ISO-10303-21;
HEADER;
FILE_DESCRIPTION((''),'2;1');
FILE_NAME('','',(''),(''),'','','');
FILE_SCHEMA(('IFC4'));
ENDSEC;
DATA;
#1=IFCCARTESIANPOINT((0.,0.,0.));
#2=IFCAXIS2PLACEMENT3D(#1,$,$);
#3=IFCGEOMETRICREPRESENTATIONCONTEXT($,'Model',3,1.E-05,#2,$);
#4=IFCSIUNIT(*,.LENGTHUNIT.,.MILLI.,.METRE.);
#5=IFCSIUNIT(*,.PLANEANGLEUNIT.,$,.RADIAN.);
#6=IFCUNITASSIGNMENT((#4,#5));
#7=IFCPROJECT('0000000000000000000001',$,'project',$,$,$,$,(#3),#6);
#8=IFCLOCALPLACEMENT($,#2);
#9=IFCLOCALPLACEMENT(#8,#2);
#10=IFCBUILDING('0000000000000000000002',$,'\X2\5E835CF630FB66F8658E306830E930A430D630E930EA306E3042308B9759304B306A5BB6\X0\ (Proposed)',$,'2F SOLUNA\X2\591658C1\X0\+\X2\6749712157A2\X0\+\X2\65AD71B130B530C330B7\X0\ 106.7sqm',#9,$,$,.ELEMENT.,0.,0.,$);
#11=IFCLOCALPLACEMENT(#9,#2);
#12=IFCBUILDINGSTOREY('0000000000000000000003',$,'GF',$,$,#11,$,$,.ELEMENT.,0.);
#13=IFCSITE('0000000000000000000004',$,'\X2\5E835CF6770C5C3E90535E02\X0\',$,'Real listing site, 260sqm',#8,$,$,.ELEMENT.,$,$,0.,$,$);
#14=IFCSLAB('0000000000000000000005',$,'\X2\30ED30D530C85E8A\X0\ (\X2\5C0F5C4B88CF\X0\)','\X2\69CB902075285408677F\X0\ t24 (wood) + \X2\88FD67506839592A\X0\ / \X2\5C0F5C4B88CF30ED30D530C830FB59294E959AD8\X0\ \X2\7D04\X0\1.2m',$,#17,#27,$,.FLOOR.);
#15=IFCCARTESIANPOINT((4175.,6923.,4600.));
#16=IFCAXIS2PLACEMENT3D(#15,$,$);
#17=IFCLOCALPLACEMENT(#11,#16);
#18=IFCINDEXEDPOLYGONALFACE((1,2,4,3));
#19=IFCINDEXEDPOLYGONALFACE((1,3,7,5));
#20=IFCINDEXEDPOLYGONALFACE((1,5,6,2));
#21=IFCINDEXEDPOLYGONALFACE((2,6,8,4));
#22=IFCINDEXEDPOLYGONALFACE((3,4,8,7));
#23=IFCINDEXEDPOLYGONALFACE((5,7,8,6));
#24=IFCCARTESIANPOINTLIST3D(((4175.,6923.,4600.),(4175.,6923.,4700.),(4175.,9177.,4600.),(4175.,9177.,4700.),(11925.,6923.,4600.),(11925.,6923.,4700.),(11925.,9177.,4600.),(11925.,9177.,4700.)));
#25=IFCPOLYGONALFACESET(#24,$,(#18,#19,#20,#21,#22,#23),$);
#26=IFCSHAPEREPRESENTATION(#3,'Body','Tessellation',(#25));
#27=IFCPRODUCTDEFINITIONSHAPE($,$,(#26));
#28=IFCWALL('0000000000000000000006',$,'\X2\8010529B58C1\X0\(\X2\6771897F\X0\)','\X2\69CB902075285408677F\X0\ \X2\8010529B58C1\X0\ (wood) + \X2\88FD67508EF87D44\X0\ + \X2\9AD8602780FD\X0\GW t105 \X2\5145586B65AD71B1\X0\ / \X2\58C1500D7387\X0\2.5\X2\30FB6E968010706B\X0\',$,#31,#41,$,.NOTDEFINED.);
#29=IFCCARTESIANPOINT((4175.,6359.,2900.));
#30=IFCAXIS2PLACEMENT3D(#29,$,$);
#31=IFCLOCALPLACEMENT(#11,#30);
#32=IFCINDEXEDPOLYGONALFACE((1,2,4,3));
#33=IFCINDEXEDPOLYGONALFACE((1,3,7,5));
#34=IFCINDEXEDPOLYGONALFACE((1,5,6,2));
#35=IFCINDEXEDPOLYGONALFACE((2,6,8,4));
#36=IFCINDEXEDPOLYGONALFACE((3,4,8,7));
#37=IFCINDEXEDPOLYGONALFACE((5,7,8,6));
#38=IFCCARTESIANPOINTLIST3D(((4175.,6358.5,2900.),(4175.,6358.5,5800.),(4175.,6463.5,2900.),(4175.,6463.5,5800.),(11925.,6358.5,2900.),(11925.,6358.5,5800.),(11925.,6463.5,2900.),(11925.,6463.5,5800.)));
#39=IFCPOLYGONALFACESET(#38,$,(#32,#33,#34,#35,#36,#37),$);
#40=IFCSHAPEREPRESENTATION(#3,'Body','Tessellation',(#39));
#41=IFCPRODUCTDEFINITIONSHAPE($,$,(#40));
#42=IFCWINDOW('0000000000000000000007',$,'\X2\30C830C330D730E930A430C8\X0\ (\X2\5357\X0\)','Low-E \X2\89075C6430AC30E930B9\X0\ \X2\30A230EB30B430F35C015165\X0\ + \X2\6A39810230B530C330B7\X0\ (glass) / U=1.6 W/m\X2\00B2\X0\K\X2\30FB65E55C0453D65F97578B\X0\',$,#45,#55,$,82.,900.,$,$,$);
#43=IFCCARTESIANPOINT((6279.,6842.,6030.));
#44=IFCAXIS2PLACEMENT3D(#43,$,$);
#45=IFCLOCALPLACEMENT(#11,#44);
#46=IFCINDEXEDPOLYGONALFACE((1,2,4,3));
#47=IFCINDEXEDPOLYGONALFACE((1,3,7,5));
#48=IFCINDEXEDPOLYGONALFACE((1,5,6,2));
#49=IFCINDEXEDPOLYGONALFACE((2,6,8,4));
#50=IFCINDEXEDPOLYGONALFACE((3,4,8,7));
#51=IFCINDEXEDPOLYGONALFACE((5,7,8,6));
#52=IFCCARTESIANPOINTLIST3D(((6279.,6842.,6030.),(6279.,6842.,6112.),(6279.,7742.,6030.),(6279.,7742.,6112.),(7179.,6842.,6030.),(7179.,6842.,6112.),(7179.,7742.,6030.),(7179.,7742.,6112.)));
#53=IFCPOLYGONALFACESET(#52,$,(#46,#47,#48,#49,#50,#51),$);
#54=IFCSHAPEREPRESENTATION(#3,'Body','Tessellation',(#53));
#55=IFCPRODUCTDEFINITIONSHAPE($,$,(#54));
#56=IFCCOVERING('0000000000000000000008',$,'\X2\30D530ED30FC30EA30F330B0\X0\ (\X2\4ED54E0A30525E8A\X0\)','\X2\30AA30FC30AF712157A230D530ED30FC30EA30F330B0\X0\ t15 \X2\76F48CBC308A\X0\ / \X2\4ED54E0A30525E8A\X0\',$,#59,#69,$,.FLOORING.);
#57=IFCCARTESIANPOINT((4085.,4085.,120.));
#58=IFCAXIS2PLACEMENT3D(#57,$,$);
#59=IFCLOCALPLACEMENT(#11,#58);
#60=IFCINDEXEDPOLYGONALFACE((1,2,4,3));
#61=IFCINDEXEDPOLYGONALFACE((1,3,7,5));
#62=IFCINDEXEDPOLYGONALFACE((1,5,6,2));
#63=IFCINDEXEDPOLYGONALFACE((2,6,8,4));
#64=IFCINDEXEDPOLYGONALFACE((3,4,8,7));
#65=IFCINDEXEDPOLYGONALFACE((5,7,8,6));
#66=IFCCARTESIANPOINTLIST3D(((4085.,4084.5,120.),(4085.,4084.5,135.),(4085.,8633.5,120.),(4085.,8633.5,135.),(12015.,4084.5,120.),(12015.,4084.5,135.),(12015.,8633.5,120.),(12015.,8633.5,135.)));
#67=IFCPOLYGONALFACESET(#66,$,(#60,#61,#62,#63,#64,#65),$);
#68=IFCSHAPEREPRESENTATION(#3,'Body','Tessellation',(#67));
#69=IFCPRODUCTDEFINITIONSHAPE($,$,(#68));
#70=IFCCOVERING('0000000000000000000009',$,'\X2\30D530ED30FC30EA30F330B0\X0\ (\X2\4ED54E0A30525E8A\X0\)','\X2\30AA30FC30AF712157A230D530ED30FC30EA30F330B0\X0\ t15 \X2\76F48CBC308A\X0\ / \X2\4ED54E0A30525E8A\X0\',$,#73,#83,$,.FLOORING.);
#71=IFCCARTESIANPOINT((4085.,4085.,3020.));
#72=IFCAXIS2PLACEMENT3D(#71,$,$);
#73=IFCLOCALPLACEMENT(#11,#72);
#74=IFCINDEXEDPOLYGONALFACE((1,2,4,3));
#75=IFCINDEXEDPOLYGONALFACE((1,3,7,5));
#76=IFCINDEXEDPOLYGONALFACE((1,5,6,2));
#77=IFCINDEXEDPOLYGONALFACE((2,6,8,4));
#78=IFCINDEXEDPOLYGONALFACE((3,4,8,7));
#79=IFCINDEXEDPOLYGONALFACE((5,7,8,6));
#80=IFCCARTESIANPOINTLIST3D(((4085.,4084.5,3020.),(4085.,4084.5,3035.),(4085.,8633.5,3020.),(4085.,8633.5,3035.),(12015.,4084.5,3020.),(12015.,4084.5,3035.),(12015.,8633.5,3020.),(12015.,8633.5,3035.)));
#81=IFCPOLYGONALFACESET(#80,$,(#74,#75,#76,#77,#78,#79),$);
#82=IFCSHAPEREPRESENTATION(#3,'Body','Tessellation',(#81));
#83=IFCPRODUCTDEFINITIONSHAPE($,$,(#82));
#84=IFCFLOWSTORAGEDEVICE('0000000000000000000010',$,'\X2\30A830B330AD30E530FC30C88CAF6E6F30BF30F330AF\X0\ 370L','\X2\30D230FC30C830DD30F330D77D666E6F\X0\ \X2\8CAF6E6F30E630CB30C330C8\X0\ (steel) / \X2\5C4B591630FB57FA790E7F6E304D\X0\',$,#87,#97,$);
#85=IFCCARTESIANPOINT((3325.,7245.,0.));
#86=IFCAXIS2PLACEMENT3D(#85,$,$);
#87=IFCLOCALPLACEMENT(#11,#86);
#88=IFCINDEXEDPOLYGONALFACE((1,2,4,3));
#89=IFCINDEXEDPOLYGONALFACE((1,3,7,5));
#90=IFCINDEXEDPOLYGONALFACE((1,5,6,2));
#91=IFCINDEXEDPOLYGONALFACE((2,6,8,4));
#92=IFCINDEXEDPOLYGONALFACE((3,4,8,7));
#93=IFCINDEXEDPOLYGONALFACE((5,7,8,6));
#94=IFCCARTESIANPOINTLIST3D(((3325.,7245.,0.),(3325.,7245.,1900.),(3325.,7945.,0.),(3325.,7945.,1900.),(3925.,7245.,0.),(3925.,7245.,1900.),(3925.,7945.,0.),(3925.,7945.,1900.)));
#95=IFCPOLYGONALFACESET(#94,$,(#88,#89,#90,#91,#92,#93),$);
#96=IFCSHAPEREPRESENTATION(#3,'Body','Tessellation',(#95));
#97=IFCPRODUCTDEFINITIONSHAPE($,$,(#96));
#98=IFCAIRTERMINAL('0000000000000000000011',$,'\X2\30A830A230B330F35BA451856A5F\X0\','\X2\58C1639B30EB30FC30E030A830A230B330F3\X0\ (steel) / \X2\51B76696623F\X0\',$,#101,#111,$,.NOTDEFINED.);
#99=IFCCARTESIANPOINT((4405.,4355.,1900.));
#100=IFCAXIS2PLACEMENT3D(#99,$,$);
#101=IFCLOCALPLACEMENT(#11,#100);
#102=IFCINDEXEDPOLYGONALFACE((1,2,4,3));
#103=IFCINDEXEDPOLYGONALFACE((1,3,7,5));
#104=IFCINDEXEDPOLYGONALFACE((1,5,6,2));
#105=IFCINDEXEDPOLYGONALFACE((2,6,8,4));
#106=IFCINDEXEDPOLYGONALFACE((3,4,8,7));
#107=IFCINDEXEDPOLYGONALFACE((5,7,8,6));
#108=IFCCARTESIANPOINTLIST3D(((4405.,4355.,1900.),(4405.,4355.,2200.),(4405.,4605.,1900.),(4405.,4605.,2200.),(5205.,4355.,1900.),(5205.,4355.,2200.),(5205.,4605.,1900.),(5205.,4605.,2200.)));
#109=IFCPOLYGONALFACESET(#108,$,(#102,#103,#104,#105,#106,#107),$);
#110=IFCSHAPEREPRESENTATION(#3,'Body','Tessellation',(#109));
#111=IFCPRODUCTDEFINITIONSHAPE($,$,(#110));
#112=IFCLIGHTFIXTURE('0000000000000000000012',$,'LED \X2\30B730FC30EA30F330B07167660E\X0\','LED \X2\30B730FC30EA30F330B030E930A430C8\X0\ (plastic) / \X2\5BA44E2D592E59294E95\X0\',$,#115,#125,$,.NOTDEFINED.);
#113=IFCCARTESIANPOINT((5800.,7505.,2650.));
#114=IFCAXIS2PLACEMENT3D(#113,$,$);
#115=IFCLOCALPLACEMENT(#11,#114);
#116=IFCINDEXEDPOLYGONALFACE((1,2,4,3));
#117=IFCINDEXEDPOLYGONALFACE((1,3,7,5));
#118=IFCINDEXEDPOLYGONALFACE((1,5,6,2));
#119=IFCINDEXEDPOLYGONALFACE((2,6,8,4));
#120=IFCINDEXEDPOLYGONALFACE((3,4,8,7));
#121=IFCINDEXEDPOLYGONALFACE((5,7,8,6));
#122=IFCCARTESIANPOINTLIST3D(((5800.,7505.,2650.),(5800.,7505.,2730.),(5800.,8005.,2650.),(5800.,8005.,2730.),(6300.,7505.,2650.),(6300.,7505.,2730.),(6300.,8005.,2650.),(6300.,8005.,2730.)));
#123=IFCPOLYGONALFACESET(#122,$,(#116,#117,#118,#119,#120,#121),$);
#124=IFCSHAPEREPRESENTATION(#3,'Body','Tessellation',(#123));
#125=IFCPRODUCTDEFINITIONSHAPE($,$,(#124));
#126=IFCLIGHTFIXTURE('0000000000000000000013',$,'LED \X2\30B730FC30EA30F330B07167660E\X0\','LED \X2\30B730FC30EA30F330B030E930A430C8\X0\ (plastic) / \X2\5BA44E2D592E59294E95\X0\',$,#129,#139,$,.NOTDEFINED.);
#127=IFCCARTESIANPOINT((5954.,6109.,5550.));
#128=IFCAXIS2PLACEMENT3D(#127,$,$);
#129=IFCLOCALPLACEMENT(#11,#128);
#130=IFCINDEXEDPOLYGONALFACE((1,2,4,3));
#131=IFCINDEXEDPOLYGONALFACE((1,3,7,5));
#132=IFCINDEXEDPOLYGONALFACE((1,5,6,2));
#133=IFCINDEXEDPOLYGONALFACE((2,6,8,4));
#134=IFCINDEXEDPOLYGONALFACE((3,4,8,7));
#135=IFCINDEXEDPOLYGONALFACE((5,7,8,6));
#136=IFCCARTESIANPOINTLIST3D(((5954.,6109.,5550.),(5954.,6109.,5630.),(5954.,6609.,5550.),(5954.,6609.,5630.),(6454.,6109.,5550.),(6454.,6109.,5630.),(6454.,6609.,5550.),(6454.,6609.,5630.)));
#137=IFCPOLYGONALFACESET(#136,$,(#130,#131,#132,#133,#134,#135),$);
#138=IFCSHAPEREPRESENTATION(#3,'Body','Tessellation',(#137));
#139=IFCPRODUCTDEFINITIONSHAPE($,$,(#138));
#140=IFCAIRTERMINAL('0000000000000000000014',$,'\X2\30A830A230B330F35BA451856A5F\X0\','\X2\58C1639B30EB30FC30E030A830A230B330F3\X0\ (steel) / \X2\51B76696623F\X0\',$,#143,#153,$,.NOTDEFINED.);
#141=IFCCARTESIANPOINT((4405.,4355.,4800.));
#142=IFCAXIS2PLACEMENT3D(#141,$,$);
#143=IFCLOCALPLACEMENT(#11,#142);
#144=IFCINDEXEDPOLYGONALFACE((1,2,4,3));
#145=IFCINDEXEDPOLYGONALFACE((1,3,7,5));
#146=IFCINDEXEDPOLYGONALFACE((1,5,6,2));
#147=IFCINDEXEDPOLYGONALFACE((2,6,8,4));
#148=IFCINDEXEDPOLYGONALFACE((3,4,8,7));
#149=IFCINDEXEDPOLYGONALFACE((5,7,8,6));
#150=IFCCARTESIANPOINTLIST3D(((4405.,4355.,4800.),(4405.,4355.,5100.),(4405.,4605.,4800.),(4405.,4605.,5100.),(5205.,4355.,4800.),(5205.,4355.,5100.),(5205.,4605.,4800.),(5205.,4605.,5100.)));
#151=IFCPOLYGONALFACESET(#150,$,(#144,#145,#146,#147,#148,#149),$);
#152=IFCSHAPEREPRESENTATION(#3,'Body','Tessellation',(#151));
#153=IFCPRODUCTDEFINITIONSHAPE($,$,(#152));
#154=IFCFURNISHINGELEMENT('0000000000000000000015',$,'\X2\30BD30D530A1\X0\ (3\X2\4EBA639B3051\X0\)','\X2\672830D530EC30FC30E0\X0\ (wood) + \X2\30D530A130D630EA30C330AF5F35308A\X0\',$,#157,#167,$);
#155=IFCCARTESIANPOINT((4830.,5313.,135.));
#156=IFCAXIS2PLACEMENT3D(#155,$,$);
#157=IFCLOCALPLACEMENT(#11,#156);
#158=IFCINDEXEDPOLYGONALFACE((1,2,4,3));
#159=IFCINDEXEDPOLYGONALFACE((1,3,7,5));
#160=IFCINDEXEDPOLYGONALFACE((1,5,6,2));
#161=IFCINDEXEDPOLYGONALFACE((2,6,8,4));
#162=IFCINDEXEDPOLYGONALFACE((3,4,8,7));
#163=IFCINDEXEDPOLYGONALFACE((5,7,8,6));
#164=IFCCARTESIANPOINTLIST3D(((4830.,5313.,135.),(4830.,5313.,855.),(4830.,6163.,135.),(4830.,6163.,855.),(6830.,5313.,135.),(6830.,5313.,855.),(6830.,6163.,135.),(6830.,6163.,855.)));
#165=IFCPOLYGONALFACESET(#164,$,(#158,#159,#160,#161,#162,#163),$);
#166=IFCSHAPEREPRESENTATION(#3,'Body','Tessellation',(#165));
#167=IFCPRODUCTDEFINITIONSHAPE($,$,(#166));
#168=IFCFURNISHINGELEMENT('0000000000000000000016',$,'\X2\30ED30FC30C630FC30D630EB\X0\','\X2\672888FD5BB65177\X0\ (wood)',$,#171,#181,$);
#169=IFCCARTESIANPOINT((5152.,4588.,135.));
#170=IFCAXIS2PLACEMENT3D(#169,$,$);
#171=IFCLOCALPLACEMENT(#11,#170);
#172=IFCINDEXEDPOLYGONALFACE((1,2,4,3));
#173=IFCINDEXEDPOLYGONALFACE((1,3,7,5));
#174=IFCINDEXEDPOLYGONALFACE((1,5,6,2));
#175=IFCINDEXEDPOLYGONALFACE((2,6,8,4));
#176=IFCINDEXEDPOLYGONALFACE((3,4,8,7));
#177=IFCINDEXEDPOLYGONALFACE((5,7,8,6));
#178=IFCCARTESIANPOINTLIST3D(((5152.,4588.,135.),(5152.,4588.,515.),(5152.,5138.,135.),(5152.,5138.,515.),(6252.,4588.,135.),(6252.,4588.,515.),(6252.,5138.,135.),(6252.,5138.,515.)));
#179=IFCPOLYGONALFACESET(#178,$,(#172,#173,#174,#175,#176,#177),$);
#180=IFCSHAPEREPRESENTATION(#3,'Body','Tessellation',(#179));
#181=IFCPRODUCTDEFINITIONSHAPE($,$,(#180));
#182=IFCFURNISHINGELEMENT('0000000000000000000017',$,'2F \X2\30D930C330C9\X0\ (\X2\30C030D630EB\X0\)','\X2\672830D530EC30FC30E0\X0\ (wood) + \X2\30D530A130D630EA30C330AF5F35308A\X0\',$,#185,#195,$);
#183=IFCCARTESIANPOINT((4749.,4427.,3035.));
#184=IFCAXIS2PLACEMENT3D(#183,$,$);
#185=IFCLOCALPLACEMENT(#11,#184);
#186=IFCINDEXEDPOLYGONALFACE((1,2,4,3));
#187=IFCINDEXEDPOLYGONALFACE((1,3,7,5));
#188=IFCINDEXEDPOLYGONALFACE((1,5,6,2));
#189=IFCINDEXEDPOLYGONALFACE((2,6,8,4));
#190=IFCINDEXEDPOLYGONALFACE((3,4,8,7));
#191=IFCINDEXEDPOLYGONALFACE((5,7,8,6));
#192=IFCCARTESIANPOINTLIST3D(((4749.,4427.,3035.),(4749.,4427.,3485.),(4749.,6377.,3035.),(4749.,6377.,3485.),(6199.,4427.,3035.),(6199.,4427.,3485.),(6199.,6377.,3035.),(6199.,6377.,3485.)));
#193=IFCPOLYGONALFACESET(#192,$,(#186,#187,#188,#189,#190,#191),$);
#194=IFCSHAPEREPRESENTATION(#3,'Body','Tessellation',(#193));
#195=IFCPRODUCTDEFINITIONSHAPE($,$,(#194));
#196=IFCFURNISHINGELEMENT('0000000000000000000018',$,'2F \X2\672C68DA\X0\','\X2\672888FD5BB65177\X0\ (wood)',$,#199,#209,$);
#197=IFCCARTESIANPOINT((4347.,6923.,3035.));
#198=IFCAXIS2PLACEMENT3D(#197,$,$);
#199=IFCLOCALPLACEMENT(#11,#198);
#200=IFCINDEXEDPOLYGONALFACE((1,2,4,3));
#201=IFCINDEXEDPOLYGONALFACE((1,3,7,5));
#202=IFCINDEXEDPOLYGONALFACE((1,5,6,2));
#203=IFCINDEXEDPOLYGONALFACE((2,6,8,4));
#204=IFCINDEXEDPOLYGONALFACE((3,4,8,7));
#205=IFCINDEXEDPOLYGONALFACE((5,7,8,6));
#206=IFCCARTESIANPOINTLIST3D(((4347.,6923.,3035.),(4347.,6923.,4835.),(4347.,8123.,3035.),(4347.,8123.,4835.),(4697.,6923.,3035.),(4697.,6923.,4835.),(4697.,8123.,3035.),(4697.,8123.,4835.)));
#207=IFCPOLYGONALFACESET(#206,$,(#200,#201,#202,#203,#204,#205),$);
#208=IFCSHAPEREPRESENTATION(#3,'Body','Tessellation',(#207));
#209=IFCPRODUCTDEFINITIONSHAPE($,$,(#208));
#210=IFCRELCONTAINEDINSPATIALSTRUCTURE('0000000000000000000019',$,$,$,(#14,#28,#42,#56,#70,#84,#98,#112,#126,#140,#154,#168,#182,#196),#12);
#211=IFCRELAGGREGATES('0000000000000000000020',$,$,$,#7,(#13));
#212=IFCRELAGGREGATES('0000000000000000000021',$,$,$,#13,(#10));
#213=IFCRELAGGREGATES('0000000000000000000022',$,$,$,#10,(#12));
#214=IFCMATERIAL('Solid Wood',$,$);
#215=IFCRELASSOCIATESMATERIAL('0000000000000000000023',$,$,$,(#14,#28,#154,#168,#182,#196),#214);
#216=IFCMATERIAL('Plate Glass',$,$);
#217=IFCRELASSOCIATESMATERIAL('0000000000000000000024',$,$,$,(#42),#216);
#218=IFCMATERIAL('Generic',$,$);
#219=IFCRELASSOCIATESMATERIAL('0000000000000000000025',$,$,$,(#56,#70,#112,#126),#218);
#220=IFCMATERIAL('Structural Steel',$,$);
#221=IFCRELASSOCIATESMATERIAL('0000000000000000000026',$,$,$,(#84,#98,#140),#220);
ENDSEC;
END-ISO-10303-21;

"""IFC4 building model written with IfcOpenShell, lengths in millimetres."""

from ifc_helpers import new_model, si_unit, frame, frame_2d, origin, place, context, project, spatial, rectangle, extrude, material, element, save


model = new_model("IFC4")

# Units and contexts
model_context = context("Model", 3, precision=1e-05, world=origin())
ifc_project = project(units=[si_unit("LENGTHUNIT", "METRE", prefix="MILLI"), si_unit("PLANEANGLEUNIT", "RADIAN")], contexts=[model_context])

# Site, building, storey
site_placement = place(None, origin())
site = spatial("IfcSite", under=ifc_project, at=site_placement, Name="広島県尾道市", ObjectType="Real listing site, 260sqm", CompositionType="ELEMENT", RefElevation=0.0)
building_placement = place(site_placement, origin())
building = spatial("IfcBuilding", under=site, at=building_placement, Name="広島・書斎とライブラリのある静かな家 (Proposed)", ObjectType="2F SOLUNA外壁+杉無垢+断熱サッシ 106.7sqm", CompositionType="ELEMENT", ElevationOfRefHeight=0.0, ElevationOfTerrain=0.0)
storey_placement = place(building_placement, origin())
storey = spatial("IfcBuildingStorey", under=building, at=storey_placement, Name="GF", CompositionType="ELEMENT", Elevation=0.0)

# Shared definitions
ifc_material_1 = material(Name="Solid Wood")

# Slab
slab_placement = place(storey_placement, frame((4175.0, 6923.0, 4600.0)))
element("IfcSlab", 1, at=slab_placement, inside=storey, material=ifc_material_1, Name="ロフト床 (小屋裏)", Description="構造用合板 t24 (wood) + 製材根太 / 小屋裏ロフト・天井高 約1.2m", PredefinedType="FLOOR", context=model_context, shape_type="SweptSolid", body=[
    extrude(rectangle(XDim=7750.0, YDim=2254.0, at=frame_2d((3875.0, 1127.0))), frame((4175.0, 6923.0, 4600.0)), (0.0, 0.0, 1.0), 100.0),
])

# Wall
wall_1_placement = place(storey_placement, frame((4175.0, 6359.0, 2900.0)))
element("IfcWall", 2, at=wall_1_placement, inside=storey, material=ifc_material_1, Name="耐力壁(東西)", Description="構造用合板 耐力壁 (wood) + 製材軸組 + 高性能GW t105 充填断熱 / 壁倍率2.5・準耐火", PredefinedType="NOTDEFINED", context=model_context, shape_type="SweptSolid", body=[
    extrude(rectangle(XDim=7750.0, YDim=105.0, at=frame_2d((3875.0, 52.0))), frame((4175.0, 6359.0, 2900.0)), (0.0, 0.0, 1.0), 2900.0),
])

# Window
ifc_material_2 = material(Name="Plate Glass")
window_placement = place(storey_placement, frame((6279.0, 6842.0, 6030.0)))
element("IfcWindow", 3, at=window_placement, inside=storey, material=ifc_material_2, Name="トップライト (南)", Description="Low-E 複層ガラス アルゴン封入 + 樹脂サッシ (glass) / U=1.6 W/m²K・日射取得型", OverallHeight=82.0, OverallWidth=900.0, context=model_context, shape_type="SweptSolid", body=[
    extrude(rectangle(XDim=900.0, YDim=900.0, at=frame_2d((450.0, 450.0))), frame((6279.0, 6842.0, 6030.0)), (0.0, 0.0, 1.0), 82.0),
])

# Coverings
ifc_material_3 = material(Name="Generic")
covering_1_placement = place(storey_placement, frame((4085.0, 4085.0, 120.0)))
element("IfcCovering", 4, at=covering_1_placement, inside=storey, material=ifc_material_3, Name="フローリング (仕上げ床)", Description="オーク無垢フローリング t15 直貼り / 仕上げ床", PredefinedType="FLOORING", context=model_context, shape_type="SweptSolid", body=[
    extrude(rectangle(XDim=7930.0, YDim=4549.0, at=frame_2d((3965.0, 2274.0))), frame((4085.0, 4085.0, 120.0)), (0.0, 0.0, 1.0), 15.0),
])
covering_2_placement = place(storey_placement, frame((4085.0, 4085.0, 3020.0)))
element("IfcCovering", 5, at=covering_2_placement, inside=storey, material=ifc_material_3, Name="フローリング (仕上げ床)", Description="オーク無垢フローリング t15 直貼り / 仕上げ床", PredefinedType="FLOORING", context=model_context, shape_type="SweptSolid", body=[
    extrude(rectangle(XDim=7930.0, YDim=4549.0, at=frame_2d((3965.0, 2274.0))), frame((4085.0, 4085.0, 3020.0)), (0.0, 0.0, 1.0), 15.0),
])

# Flow storage device
ifc_material_4 = material(Name="Structural Steel")
flow_storage_device_placement = place(storey_placement, frame((3325.0, 7245.0, 0.0)))
element("IfcFlowStorageDevice", 6, at=flow_storage_device_placement, inside=storey, material=ifc_material_4, Name="エコキュート貯湯タンク 370L", Description="ヒートポンプ給湯 貯湯ユニット (steel) / 屋外・基礎置き", context=model_context, shape_type="SweptSolid", body=[
    extrude(rectangle(XDim=600.0, YDim=700.0, at=frame_2d((300.0, 350.0))), frame((3325.0, 7245.0, 0.0)), (0.0, 0.0, 1.0), 1900.0),
])

# Air terminal
air_terminal_1_placement = place(storey_placement, frame((4405.0, 4355.0, 1900.0)))
element("IfcAirTerminal", 7, at=air_terminal_1_placement, inside=storey, material=ifc_material_4, Name="エアコン室内機", Description="壁掛ルームエアコン (steel) / 冷暖房", PredefinedType="NOTDEFINED", context=model_context, shape_type="SweptSolid", body=[
    extrude(rectangle(XDim=800.0, YDim=250.0, at=frame_2d((400.0, 125.0))), frame((4405.0, 4355.0, 1900.0)), (0.0, 0.0, 1.0), 300.0),
])

# Light fixtures
light_fixture_1_placement = place(storey_placement, frame((5800.0, 7505.0, 2650.0)))
element("IfcLightFixture", 8, at=light_fixture_1_placement, inside=storey, material=ifc_material_3, Name="LED シーリング照明", Description="LED シーリングライト (plastic) / 室中央天井", PredefinedType="NOTDEFINED", context=model_context, shape_type="SweptSolid", body=[
    extrude(rectangle(XDim=500.0, YDim=500.0, at=frame_2d((250.0, 250.0))), frame((5800.0, 7505.0, 2650.0)), (0.0, 0.0, 1.0), 80.0),
])
light_fixture_2_placement = place(storey_placement, frame((5954.0, 6109.0, 5550.0)))
element("IfcLightFixture", 9, at=light_fixture_2_placement, inside=storey, material=ifc_material_3, Name="LED シーリング照明", Description="LED シーリングライト (plastic) / 室中央天井", PredefinedType="NOTDEFINED", context=model_context, shape_type="SweptSolid", body=[
    extrude(rectangle(XDim=500.0, YDim=500.0, at=frame_2d((250.0, 250.0))), frame((5954.0, 6109.0, 5550.0)), (0.0, 0.0, 1.0), 80.0),
])

# Air terminal
air_terminal_2_placement = place(storey_placement, frame((4405.0, 4355.0, 4800.0)))
element("IfcAirTerminal", 10, at=air_terminal_2_placement, inside=storey, material=ifc_material_4, Name="エアコン室内機", Description="壁掛ルームエアコン (steel) / 冷暖房", PredefinedType="NOTDEFINED", context=model_context, shape_type="SweptSolid", body=[
    extrude(rectangle(XDim=800.0, YDim=250.0, at=frame_2d((400.0, 125.0))), frame((4405.0, 4355.0, 4800.0)), (0.0, 0.0, 1.0), 300.0),
])

# Furnishing elements
furnishing_1_placement = place(storey_placement, frame((4830.0, 5313.0, 135.0)))
element("IfcFurnishingElement", 11, at=furnishing_1_placement, inside=storey, material=ifc_material_1, Name="ソファ (3人掛け)", Description="木フレーム (wood) + ファブリック張り", context=model_context, shape_type="SweptSolid", body=[
    extrude(rectangle(XDim=2000.0, YDim=850.0, at=frame_2d((1000.0, 425.0))), frame((4830.0, 5313.0, 135.0)), (0.0, 0.0, 1.0), 720.0),
])
furnishing_2_placement = place(storey_placement, frame((5152.0, 4588.0, 135.0)))
element("IfcFurnishingElement", 12, at=furnishing_2_placement, inside=storey, material=ifc_material_1, Name="ローテーブル", Description="木製家具 (wood)", context=model_context, shape_type="SweptSolid", body=[
    extrude(rectangle(XDim=1100.0, YDim=550.0, at=frame_2d((550.0, 275.0))), frame((5152.0, 4588.0, 135.0)), (0.0, 0.0, 1.0), 380.0),
])
furnishing_3_placement = place(storey_placement, frame((4749.0, 4427.0, 3035.0)))
element("IfcFurnishingElement", 13, at=furnishing_3_placement, inside=storey, material=ifc_material_1, Name="2F ベッド (ダブル)", Description="木フレーム (wood) + ファブリック張り", context=model_context, shape_type="SweptSolid", body=[
    extrude(rectangle(XDim=1450.0, YDim=1950.0, at=frame_2d((725.0, 975.0))), frame((4749.0, 4427.0, 3035.0)), (0.0, 0.0, 1.0), 450.0),
])
furnishing_4_placement = place(storey_placement, frame((4347.0, 6923.0, 3035.0)))
element("IfcFurnishingElement", 14, at=furnishing_4_placement, inside=storey, material=ifc_material_1, Name="2F 本棚", Description="木製家具 (wood)", context=model_context, shape_type="SweptSolid", body=[
    extrude(rectangle(XDim=350.0, YDim=1200.0, at=frame_2d((175.0, 600.0))), frame((4347.0, 6923.0, 3035.0)), (0.0, 0.0, 1.0), 1800.0),
])

save(model, "model.ifc")
